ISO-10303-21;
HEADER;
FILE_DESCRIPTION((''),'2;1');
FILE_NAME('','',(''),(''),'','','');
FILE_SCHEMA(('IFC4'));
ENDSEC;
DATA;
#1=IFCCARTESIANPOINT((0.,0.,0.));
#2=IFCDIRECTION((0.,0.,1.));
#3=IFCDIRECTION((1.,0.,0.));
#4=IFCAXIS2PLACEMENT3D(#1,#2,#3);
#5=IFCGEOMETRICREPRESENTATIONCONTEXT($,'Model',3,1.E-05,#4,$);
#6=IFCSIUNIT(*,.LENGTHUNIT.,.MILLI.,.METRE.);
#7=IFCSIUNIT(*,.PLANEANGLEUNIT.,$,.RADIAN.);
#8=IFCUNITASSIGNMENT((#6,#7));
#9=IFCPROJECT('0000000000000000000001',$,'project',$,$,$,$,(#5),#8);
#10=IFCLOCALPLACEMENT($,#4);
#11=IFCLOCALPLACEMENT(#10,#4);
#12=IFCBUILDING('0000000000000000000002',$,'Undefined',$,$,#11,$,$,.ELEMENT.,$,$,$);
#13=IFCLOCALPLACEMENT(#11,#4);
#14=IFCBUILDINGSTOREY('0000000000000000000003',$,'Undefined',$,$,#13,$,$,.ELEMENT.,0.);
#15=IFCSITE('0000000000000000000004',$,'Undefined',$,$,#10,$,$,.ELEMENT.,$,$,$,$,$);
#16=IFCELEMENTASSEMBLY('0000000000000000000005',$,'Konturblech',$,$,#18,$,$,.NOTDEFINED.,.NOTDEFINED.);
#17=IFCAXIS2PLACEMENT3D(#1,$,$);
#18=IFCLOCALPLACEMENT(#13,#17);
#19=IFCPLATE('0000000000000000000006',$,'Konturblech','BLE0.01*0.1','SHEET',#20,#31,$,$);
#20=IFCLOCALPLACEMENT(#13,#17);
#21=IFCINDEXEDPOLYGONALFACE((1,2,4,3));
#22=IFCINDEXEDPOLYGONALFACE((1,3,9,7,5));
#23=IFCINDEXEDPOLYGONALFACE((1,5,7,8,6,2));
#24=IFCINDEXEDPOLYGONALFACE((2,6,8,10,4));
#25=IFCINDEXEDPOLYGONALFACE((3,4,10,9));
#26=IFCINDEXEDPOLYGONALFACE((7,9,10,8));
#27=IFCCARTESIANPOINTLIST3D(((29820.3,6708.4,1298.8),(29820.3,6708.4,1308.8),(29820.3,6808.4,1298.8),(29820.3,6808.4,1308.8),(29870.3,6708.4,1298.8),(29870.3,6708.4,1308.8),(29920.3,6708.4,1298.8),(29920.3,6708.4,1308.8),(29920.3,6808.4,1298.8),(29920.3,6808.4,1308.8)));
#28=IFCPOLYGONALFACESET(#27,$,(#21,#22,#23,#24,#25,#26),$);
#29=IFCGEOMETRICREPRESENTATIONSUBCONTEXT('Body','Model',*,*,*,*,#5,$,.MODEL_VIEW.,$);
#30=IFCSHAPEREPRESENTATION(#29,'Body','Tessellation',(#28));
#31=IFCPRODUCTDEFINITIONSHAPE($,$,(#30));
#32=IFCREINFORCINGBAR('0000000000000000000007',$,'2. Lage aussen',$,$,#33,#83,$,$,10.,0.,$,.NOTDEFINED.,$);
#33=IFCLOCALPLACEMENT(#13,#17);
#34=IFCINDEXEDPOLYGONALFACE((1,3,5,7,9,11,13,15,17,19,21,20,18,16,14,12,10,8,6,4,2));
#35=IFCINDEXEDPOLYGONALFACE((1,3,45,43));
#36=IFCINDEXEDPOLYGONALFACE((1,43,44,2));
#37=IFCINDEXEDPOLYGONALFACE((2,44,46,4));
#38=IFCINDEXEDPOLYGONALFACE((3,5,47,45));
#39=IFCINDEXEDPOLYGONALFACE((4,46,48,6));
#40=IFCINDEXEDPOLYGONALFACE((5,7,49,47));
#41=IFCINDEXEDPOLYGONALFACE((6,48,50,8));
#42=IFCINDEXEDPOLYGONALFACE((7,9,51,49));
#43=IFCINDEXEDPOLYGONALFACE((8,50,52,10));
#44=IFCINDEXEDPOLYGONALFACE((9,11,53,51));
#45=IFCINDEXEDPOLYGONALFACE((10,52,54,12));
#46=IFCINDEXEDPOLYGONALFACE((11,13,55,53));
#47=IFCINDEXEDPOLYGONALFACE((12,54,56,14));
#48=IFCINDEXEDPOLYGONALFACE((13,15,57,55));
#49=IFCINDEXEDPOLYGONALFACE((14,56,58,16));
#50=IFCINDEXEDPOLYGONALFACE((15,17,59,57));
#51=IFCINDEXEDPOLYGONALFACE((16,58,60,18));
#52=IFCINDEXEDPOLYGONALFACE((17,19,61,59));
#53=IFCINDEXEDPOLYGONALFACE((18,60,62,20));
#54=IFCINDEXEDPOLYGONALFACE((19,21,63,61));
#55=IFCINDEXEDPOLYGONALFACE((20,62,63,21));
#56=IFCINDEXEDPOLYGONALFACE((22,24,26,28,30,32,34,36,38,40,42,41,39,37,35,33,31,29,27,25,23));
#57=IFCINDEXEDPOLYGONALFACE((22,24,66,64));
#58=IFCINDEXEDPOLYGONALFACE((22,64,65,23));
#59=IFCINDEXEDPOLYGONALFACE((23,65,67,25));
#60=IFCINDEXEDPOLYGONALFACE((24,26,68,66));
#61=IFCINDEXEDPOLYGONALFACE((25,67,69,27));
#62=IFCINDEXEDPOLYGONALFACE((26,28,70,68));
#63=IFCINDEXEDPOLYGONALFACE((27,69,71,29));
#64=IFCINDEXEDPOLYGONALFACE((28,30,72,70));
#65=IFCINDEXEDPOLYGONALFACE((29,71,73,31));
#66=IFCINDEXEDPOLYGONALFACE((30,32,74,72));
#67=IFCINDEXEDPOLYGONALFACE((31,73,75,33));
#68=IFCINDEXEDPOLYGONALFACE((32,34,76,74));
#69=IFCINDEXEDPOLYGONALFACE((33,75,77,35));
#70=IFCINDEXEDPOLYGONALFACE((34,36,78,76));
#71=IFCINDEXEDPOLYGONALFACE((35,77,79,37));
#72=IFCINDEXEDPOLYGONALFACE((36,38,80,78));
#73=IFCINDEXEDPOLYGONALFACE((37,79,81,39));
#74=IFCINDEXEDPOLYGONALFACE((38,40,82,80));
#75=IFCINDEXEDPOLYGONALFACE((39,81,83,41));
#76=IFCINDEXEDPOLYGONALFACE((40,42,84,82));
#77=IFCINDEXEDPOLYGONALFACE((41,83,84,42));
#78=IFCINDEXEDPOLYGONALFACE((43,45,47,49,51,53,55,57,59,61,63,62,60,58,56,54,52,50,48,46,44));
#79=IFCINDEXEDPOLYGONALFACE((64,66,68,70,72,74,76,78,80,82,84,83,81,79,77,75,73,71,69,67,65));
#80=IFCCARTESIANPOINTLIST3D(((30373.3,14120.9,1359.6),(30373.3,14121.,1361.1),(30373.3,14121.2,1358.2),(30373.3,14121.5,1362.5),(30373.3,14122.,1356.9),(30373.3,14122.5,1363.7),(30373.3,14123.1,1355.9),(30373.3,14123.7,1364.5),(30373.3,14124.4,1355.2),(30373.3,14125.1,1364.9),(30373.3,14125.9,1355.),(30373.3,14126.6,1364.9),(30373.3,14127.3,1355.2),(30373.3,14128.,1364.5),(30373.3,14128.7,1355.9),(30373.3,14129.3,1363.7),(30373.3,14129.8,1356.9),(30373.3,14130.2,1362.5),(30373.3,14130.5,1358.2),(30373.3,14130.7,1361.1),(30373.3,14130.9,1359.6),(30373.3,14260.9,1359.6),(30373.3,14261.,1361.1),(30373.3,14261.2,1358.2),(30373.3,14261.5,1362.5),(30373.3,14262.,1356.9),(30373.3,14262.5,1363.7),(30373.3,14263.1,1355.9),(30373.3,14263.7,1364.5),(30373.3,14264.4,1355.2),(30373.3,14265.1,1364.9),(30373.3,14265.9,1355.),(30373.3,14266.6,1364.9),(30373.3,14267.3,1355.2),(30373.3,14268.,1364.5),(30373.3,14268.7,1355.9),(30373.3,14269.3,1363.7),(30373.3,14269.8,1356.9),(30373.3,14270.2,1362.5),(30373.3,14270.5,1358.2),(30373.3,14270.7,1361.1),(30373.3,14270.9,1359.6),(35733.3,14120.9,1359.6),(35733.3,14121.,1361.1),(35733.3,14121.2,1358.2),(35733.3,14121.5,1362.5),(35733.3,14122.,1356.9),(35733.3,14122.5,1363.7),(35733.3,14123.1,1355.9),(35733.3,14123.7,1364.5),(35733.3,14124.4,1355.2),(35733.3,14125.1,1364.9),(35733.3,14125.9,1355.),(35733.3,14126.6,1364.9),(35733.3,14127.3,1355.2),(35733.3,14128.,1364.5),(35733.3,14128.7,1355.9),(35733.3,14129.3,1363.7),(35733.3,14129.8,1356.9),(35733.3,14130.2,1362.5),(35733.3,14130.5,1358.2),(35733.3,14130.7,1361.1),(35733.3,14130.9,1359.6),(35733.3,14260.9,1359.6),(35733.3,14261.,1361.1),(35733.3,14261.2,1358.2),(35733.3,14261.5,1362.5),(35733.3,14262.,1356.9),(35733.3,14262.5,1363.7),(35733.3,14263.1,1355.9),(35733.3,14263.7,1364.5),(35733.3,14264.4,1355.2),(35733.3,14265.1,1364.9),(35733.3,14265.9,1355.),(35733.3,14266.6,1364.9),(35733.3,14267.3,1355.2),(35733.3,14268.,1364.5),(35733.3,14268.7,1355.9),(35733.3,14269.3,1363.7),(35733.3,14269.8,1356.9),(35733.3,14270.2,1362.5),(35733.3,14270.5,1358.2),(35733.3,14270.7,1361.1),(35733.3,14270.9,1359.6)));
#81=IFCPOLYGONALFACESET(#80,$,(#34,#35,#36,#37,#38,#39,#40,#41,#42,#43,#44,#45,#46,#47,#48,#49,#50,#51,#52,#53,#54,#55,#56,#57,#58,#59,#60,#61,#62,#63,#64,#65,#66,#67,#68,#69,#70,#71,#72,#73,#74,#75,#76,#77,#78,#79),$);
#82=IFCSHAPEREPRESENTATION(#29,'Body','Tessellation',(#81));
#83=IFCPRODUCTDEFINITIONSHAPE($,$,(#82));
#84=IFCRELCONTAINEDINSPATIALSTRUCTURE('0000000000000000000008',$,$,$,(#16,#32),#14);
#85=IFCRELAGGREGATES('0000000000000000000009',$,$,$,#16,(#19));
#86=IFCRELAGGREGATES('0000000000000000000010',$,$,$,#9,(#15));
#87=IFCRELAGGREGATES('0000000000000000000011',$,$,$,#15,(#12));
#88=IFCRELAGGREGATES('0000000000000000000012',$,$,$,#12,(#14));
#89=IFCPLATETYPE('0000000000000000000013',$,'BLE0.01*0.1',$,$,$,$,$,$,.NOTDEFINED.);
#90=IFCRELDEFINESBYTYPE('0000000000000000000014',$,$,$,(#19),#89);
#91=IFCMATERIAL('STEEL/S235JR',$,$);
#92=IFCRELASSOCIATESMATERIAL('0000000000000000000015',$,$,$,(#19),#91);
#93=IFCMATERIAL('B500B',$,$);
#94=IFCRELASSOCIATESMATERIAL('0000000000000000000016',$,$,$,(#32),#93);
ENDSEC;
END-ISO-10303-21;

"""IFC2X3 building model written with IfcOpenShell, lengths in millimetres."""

from ifc_helpers import new_model, entity, si_unit, frame, origin_with_axes, place, context, subcontext, project, spatial, polyline, outline, extrude, source, transform, mapped, material, type_object, element, aggregate, save


model = new_model("IFC2X3")

# Units and contexts
model_context = context("Model", 3, precision=1e-05, world=origin_with_axes())
body_context = subcontext(model_context, "Body", "Model", "MODEL_VIEW")
ifc_project = project(units=[si_unit("LENGTHUNIT", "METRE", prefix="MILLI"), si_unit("PLANEANGLEUNIT", "RADIAN")], contexts=[model_context])

# Site, building, storey
site_placement = place(None, origin_with_axes())
site = spatial("IfcSite", under=ifc_project, at=site_placement, Name="Undefined", CompositionType="ELEMENT")
building_placement = place(site_placement, origin_with_axes())
building = spatial("IfcBuilding", under=site, at=building_placement, Name="Undefined", CompositionType="ELEMENT")
storey_placement = place(building_placement, origin_with_axes())
storey = spatial("IfcBuildingStorey", under=building, at=storey_placement, Name="Undefined", CompositionType="ELEMENT", Elevation=0.0)

# Shared definitions
ifc_material_1 = material(Name="STEEL/S235JR")

# Element assembly, plate
plate_type = type_object("IfcPlateType", Name="BLE0.01*0.1", PredefinedType="NOTDEFINED")
assembly_1_placement = place(storey_placement, origin_with_axes())
assembly_1 = element("IfcElementAssembly", 1, at=assembly_1_placement, inside=storey, Name="Konturblech", AssemblyPlace="NOTDEFINED", PredefinedType="NOTDEFINED")
plate_1_placement = place(assembly_1_placement, frame((29870.3, 6708.4, 1303.8), z_axis=(0.0, 0.0, 1.0), x_axis=(1.0, 0.0, 0.0)))
plate_1 = element("IfcPlate", 2, at=plate_1_placement, type_object=plate_type, material=ifc_material_1, Name="Konturblech", Description="BLE0.01*0.1", ObjectType="SHEET", context=body_context, shape_type="SweptSolid", body=[
    extrude(outline(polyline([(0.0, 0.0), (50.0, 0.0), (50.0, 100.0), (-50.0, 100.0), (-50.0, 0.0), (0.0, 0.0)])), frame((0.0, 0.0, -5.0), z_axis=(0.0, 0.0, 1.0), x_axis=(1.0, 0.0, 0.0)), (0.0, 0.0, 1.0), 10.0),
])

aggregate(assembly_1, [plate_1])

# Reinforcing bar
ifc_material_2 = material(Name="B500B")
shared_shape_1 = source(origin_with_axes(), body_context, "Body", "AdvancedSweptSolid", [
    entity("IfcSweptDiskSolid", entity("IfcTrimmedCurve", entity("IfcLine", entity("IfcCartesianPoint", [0.0, 0.0, 0.0]), entity("IfcVector", entity("IfcDirection", [1.0, 0.0, 0.0]), 1.0)), [entity("IfcParameterValue", 0.0)], [entity("IfcParameterValue", 5360.0)], True, "PARAMETER"), 5.0, None, 0.0, 5360.0),
])
shared_shape_2 = source(origin_with_axes(), body_context, "Body", "AdvancedSweptSolid", [
    entity("IfcSweptDiskSolid", entity("IfcTrimmedCurve", entity("IfcLine", entity("IfcCartesianPoint", [0.0, 0.0, 0.0]), entity("IfcVector", entity("IfcDirection", [1.0, 0.0, 0.0]), 1.0)), [entity("IfcParameterValue", 0.0)], [entity("IfcParameterValue", 5360.0)], True, "PARAMETER"), 5.0, None, 0.0, 5360.0),
])
reinforcing_bar_1_placement = place(storey_placement, frame((30373.3, 14125.9, 1360.0), z_axis=(0.0, 0.0, -1.0), x_axis=(1.0, 0.0, 0.0)))
element("IfcReinforcingBar", 3, at=reinforcing_bar_1_placement, inside=storey, material=ifc_material_2, Name="2. Lage aussen", BarRole="NOTDEFINED", CrossSectionArea=0.0, NominalDiameter=10.0, context=body_context, shape_type="MappedRepresentation", body=[
    mapped(shared_shape_1, transform((0.0, 0.0, 0.0))),
    mapped(shared_shape_2, transform((0.0, -140.0, 0.0))),
])

save(model, "model.ifc")
